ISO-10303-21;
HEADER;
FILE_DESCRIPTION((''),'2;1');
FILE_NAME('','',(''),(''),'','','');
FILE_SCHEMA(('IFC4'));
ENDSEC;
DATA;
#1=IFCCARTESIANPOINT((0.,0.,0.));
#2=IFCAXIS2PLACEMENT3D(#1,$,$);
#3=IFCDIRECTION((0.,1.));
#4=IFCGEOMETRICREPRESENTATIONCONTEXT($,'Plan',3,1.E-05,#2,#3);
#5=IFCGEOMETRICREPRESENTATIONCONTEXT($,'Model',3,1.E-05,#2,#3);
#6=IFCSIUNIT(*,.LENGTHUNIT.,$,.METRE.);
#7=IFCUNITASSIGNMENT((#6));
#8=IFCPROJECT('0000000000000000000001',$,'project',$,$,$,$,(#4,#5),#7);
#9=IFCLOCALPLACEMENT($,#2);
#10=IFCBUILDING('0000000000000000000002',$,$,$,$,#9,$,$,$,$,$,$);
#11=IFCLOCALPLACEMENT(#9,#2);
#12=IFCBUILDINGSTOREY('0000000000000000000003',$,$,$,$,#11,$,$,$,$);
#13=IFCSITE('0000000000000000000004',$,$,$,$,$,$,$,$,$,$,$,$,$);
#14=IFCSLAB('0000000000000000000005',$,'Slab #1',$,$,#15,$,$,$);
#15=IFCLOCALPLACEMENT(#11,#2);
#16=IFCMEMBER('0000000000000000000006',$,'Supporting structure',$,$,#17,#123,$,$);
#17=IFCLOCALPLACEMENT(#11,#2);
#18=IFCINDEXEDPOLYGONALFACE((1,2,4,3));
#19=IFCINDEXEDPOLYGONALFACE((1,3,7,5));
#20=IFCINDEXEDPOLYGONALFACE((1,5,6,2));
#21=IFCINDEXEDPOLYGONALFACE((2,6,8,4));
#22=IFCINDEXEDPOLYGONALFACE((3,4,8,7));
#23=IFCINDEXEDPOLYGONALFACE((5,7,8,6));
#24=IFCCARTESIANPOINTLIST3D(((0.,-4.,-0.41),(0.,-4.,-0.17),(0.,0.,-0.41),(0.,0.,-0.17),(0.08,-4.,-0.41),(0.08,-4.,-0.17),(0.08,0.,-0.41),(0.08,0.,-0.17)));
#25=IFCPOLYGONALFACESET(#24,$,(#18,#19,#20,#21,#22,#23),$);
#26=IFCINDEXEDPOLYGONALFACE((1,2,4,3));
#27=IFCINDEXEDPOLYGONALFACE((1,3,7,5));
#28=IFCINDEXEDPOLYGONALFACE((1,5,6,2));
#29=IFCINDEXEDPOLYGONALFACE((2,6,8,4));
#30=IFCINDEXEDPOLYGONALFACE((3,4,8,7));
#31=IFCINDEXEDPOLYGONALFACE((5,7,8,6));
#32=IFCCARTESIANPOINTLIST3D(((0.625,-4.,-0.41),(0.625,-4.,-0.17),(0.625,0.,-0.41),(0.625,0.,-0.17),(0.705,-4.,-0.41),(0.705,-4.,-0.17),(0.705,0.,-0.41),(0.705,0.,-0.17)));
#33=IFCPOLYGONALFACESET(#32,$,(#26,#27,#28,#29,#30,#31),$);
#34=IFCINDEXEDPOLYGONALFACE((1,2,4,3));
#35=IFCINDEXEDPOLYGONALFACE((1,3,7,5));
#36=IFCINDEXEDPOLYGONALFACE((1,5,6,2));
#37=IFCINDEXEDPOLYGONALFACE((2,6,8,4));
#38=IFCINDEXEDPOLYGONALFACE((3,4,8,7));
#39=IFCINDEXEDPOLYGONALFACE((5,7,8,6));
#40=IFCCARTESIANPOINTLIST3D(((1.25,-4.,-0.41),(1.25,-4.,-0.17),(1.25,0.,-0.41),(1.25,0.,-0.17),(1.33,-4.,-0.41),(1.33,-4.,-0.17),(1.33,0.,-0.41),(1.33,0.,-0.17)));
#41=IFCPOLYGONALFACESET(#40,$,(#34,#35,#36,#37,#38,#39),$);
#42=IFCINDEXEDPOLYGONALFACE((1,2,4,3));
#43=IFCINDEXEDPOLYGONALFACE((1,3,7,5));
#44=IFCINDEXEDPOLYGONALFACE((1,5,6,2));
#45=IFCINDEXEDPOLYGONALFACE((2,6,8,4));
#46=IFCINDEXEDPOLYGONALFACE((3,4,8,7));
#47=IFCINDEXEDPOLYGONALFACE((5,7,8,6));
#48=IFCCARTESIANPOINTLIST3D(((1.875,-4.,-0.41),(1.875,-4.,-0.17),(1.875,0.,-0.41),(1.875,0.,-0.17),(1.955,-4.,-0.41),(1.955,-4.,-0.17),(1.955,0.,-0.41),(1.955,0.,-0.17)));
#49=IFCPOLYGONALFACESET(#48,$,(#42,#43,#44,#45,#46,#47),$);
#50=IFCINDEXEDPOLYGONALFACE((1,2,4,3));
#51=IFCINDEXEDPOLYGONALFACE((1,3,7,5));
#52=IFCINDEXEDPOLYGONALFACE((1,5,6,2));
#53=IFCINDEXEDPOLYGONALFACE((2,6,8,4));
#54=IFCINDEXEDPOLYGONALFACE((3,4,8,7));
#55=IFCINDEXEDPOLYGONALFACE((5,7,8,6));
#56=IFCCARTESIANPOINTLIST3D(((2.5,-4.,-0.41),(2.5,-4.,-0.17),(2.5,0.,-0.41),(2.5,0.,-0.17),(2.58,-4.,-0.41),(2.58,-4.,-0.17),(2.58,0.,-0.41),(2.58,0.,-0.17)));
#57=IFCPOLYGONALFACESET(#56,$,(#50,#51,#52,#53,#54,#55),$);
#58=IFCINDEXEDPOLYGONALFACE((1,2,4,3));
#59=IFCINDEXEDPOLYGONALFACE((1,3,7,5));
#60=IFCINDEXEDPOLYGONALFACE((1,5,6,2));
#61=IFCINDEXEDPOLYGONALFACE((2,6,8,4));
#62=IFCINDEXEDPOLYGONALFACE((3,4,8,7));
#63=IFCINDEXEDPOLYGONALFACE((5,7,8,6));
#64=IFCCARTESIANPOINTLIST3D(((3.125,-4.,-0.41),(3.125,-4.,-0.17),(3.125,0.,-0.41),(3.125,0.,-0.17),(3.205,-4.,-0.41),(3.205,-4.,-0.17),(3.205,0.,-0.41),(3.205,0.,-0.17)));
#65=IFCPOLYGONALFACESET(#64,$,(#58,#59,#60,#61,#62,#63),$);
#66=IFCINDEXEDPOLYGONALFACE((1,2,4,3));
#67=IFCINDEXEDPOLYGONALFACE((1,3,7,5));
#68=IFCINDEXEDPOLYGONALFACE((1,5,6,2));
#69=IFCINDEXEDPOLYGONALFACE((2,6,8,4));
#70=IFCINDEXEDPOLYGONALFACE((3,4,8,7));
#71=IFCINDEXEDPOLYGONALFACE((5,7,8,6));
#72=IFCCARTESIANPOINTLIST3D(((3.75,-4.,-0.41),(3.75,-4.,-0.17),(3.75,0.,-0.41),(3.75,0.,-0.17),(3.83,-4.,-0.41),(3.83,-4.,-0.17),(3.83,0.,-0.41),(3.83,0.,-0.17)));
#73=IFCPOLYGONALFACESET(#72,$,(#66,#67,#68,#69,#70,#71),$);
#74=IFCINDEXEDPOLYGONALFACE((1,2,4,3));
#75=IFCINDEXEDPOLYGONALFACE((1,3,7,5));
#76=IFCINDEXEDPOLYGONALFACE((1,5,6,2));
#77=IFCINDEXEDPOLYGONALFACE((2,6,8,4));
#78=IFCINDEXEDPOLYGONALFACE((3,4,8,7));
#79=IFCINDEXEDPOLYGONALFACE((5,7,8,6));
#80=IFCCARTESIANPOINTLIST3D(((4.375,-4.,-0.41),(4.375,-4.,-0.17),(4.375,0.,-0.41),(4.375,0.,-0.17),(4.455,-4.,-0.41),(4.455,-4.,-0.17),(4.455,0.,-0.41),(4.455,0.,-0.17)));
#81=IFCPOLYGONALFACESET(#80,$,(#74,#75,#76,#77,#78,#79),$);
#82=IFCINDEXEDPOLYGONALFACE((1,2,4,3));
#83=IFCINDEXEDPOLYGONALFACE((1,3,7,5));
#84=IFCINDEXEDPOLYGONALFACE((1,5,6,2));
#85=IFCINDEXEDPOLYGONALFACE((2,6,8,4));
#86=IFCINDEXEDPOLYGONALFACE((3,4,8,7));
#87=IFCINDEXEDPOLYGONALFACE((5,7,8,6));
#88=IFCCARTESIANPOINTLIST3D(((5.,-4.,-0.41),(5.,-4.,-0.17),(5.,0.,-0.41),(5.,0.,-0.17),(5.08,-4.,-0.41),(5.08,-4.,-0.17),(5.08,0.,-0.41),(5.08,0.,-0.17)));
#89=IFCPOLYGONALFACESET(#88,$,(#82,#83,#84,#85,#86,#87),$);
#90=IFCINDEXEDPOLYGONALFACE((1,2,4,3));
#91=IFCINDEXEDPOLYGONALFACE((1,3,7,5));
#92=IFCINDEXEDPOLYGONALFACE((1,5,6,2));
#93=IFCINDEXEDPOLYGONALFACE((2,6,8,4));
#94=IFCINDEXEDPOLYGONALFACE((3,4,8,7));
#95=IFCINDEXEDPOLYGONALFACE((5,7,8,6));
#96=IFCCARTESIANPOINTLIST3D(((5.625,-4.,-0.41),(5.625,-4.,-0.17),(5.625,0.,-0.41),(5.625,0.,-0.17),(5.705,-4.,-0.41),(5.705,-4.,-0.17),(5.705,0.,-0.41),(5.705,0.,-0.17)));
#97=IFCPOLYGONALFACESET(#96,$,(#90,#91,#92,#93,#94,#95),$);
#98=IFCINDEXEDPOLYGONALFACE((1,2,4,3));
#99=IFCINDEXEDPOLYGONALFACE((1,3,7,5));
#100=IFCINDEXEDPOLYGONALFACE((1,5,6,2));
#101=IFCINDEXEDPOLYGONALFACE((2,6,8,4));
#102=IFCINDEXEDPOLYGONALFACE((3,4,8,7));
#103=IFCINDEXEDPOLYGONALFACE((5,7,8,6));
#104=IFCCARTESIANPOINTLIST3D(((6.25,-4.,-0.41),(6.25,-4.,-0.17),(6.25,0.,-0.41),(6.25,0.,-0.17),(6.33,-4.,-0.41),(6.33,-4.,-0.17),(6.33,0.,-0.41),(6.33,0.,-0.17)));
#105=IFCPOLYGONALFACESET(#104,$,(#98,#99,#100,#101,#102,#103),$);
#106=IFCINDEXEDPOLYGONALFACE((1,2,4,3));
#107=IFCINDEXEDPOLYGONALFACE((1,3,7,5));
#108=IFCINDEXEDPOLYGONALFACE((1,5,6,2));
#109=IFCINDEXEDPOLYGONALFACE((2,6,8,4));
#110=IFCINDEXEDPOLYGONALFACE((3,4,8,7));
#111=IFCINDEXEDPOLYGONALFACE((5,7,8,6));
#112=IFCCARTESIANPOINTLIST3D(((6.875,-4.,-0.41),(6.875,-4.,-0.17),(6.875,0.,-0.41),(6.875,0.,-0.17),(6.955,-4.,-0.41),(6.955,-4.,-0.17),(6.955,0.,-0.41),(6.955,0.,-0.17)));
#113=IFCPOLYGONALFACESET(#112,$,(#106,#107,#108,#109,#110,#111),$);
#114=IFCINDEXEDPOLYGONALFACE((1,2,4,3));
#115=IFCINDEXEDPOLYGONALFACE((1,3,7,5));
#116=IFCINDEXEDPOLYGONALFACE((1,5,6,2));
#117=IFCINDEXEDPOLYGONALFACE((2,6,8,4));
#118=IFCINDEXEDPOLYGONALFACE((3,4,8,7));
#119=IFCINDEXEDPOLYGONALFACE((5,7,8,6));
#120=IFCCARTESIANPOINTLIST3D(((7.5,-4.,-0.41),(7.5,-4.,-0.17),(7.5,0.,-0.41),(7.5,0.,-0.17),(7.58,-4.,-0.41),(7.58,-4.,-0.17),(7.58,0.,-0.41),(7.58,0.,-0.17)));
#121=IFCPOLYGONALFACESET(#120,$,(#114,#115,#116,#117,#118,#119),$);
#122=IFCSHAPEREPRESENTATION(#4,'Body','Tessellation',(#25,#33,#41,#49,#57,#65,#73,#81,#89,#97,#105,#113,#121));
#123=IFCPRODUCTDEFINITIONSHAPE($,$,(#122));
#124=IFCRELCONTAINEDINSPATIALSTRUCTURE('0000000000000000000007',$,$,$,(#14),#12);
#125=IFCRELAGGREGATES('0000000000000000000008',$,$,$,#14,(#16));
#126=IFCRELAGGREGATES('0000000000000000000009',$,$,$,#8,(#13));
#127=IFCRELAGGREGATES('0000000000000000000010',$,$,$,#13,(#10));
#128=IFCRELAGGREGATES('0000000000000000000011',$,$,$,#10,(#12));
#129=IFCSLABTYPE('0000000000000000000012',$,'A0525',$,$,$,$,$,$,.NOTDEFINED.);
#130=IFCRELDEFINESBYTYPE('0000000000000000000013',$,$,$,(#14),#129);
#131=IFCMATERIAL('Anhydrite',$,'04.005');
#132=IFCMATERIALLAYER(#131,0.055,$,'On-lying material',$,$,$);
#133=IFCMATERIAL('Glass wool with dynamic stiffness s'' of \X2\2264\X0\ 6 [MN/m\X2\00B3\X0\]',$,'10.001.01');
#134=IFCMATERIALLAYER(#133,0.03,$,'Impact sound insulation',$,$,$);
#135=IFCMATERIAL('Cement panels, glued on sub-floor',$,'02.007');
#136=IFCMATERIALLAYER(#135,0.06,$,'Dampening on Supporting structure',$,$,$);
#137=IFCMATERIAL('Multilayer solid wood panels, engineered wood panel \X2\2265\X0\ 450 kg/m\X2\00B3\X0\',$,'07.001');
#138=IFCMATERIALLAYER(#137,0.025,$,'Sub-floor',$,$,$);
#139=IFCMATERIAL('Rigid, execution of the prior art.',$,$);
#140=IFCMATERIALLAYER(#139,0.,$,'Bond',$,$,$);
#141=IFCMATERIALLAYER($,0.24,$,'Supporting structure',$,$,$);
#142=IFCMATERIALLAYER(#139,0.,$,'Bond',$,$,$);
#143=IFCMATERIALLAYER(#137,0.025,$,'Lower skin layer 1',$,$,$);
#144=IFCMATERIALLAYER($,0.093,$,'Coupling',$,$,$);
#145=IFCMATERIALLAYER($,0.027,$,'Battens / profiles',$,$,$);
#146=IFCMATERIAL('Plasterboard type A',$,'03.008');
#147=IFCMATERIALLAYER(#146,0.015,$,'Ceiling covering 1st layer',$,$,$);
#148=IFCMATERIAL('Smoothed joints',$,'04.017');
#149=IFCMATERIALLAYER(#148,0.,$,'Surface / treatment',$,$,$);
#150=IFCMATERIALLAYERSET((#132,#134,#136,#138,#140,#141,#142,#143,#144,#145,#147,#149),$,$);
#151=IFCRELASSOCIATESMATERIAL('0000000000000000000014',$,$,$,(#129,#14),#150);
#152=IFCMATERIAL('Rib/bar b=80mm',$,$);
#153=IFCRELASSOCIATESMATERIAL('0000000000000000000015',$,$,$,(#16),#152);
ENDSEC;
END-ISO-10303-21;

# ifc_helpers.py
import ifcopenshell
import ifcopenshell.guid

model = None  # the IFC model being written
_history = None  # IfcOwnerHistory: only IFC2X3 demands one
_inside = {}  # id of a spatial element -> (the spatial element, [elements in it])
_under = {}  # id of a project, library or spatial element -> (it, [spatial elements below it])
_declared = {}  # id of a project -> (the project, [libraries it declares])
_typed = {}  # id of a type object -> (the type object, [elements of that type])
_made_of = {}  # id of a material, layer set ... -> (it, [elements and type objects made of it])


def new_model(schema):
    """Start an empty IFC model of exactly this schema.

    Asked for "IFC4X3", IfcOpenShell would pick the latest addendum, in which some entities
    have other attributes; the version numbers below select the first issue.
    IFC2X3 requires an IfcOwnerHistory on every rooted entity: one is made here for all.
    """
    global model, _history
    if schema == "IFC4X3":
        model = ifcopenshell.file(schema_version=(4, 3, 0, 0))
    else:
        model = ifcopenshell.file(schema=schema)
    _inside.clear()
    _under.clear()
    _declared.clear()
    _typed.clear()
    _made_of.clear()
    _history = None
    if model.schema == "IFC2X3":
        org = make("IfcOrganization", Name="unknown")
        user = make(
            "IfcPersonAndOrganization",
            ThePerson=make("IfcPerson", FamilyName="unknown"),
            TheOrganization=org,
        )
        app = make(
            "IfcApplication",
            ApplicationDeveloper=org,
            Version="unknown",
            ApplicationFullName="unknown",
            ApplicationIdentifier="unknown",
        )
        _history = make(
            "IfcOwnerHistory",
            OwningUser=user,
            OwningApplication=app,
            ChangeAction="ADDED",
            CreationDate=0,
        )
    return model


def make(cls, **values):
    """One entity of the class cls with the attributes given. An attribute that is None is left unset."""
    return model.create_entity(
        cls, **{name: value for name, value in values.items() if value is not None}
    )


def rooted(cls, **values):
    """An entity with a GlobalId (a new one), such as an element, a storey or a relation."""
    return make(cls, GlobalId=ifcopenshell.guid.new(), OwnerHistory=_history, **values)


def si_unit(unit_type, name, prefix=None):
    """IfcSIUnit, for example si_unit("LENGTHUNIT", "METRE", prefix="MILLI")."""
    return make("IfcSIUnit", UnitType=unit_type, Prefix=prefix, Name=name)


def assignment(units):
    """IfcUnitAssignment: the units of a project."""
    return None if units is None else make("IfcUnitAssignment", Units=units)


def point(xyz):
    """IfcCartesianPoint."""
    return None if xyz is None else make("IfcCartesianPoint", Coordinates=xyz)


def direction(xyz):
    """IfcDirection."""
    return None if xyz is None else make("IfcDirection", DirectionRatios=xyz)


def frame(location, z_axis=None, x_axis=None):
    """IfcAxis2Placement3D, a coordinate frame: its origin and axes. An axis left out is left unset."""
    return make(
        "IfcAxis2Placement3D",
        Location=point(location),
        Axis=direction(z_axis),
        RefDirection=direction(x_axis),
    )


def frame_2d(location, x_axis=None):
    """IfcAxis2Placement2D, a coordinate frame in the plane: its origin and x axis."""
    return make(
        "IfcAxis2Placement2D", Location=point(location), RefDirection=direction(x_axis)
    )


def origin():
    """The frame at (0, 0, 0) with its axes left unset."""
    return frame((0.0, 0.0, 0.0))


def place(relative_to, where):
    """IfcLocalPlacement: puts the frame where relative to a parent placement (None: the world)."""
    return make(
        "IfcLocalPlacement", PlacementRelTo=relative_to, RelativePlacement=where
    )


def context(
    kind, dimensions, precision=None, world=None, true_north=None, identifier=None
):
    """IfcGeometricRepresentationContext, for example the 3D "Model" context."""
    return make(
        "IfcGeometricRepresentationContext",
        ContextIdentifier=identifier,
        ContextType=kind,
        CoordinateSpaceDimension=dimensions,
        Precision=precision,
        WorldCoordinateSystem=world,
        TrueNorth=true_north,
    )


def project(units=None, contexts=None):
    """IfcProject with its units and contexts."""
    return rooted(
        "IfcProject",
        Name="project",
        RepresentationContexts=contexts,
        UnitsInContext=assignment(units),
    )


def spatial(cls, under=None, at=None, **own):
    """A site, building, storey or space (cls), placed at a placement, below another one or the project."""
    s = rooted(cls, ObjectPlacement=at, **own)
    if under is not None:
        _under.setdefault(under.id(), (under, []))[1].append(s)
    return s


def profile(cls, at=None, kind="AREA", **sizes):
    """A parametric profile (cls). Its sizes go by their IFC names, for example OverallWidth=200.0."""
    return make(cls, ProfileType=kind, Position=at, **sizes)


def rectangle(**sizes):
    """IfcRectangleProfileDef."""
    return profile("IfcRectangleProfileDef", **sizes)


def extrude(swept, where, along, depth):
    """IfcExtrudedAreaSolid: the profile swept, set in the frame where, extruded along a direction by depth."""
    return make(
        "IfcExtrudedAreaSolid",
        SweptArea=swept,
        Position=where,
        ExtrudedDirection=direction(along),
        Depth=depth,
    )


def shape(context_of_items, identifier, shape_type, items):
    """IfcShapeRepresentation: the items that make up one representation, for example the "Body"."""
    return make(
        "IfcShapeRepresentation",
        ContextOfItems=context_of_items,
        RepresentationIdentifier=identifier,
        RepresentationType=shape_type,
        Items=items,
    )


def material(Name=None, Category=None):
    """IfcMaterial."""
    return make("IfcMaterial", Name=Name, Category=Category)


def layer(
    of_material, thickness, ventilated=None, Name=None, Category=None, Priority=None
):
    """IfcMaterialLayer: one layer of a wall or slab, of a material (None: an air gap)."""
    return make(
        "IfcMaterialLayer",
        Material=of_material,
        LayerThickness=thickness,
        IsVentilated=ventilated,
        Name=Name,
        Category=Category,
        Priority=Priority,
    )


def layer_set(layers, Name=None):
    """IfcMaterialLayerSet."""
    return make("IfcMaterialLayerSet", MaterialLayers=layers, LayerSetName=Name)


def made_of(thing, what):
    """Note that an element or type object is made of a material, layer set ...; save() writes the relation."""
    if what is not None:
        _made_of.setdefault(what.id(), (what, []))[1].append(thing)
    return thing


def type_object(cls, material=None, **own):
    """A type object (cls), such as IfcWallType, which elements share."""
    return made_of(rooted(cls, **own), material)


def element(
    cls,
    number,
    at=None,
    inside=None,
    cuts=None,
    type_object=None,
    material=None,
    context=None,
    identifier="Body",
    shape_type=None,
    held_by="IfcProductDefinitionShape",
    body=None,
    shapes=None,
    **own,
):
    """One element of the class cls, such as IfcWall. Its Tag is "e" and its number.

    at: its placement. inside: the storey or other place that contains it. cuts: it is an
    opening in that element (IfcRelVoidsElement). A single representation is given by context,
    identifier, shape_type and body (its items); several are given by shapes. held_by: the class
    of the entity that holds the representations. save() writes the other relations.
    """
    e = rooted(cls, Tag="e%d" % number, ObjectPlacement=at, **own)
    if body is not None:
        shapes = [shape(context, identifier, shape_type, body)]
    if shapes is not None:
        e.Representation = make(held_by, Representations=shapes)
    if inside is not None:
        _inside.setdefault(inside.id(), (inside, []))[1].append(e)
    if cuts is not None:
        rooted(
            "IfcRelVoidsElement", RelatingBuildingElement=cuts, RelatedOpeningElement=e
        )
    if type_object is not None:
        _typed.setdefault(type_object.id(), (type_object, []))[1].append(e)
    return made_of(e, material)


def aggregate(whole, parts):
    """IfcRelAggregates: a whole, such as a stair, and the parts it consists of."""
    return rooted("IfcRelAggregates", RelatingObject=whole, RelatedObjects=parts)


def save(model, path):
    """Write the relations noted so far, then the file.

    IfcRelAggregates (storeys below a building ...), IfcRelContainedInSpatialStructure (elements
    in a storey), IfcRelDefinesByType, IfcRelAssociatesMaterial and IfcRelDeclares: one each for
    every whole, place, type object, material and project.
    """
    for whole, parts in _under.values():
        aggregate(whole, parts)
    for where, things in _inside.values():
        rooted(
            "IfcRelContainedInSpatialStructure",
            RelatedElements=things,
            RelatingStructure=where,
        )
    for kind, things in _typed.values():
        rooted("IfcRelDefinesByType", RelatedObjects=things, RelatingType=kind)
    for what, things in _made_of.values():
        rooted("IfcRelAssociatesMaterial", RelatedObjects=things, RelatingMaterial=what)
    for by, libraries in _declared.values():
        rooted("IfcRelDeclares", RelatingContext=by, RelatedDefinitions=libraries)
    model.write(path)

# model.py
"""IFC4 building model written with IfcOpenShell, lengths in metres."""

from ifc_helpers import new_model, si_unit, direction, frame, frame_2d, origin, place, context, project, spatial, rectangle, extrude, material, layer, layer_set, type_object, element, aggregate, save


model = new_model("IFC4")

# Units and contexts
plan_context = context("Plan", 3, precision=1e-05, world=origin(), true_north=direction((0.0, 1.0)))
model_context = context("Model", 3, precision=1e-05, world=origin(), true_north=direction((0.0, 1.0)))
ifc_project = project(units=[si_unit("LENGTHUNIT", "METRE")], contexts=[plan_context, model_context])

# Site, building, storey
site = spatial("IfcSite", under=ifc_project)
building_placement = place(None, origin())
building = spatial("IfcBuilding", under=site, at=building_placement)
storey_placement = place(building_placement, origin())
storey = spatial("IfcBuildingStorey", under=building, at=storey_placement)

# Slab, member
ifc_material_1 = material(Name="Anhydrite", Category="04.005")
ifc_layer_1 = layer(ifc_material_1, 0.055, Name="On-lying material")
ifc_material_2 = material(Name="Glass wool with dynamic stiffness s' of ≤ 6 [MN/m³]", Category="10.001.01")
ifc_layer_2 = layer(ifc_material_2, 0.03, Name="Impact sound insulation")
ifc_material_3 = material(Name="Cement panels, glued on sub-floor", Category="02.007")
ifc_layer_3 = layer(ifc_material_3, 0.06, Name="Dampening on Supporting structure")
ifc_material_4 = material(Name="Multilayer solid wood panels, engineered wood panel ≥ 450 kg/m³", Category="07.001")
ifc_layer_4 = layer(ifc_material_4, 0.025, Name="Sub-floor")
ifc_material_5 = material(Name="Rigid, execution of the prior art.")
ifc_layer_5 = layer(ifc_material_5, 0.0, Name="Bond")
ifc_layer_6 = layer(None, 0.24, Name="Supporting structure")
ifc_layer_7 = layer(ifc_material_5, 0.0, Name="Bond")
ifc_layer_8 = layer(ifc_material_4, 0.025, Name="Lower skin layer 1")
ifc_layer_9 = layer(None, 0.093, Name="Coupling")
ifc_layer_10 = layer(None, 0.027, Name="Battens / profiles")
ifc_material_6 = material(Name="Plasterboard type A", Category="03.008")
ifc_layer_11 = layer(ifc_material_6, 0.015, Name="Ceiling covering 1st layer")
ifc_material_7 = material(Name="Smoothed joints", Category="04.017")
ifc_layer_12 = layer(ifc_material_7, 0.0, Name="Surface / treatment")
ifc_layer_set = layer_set([ifc_layer_1, ifc_layer_2, ifc_layer_3, ifc_layer_4, ifc_layer_5, ifc_layer_6, ifc_layer_7, ifc_layer_8, ifc_layer_9, ifc_layer_10, ifc_layer_11, ifc_layer_12])
slab_type = type_object("IfcSlabType", Name="A0525", PredefinedType="NOTDEFINED", material=ifc_layer_set)
slab_placement = place(None, frame((0.0, 0.0, 0.0), z_axis=(0.0, 0.0, -1.0), x_axis=(1.0, 0.0, 0.0)))
slab = element("IfcSlab", 1, at=slab_placement, inside=storey, type_object=slab_type, material=ifc_layer_set, Name="Slab #1")
ifc_material_8 = material(Name="Rib/bar b=80mm")
member_1_placement = place(slab_placement, origin())
member_1 = element("IfcMember", 2, at=member_1_placement, material=ifc_material_8, Name="Supporting structure", context=plan_context, shape_type="SweptSolid", body=[
    extrude(rectangle(XDim=0.08, YDim=0.24, at=frame_2d((0.04, 0.12), x_axis=(1.0, 0.0))), frame((0.0, 4.0, 0.17), z_axis=(0.0, -1.0, 0.0), x_axis=(1.0, 0.0, 0.0)), (0.0, 0.0, 1.0), 4.0),
    extrude(rectangle(XDim=0.08, YDim=0.24, at=frame_2d((0.04, 0.12), x_axis=(1.0, 0.0))), frame((0.625, 4.0, 0.17), z_axis=(0.0, -1.0, 0.0), x_axis=(1.0, 0.0, 0.0)), (0.0, 0.0, 1.0), 4.0),
    extrude(rectangle(XDim=0.08, YDim=0.24, at=frame_2d((0.04, 0.12), x_axis=(1.0, 0.0))), frame((1.25, 4.0, 0.17), z_axis=(0.0, -1.0, 0.0), x_axis=(1.0, 0.0, 0.0)), (0.0, 0.0, 1.0), 4.0),
    extrude(rectangle(XDim=0.08, YDim=0.24, at=frame_2d((0.04, 0.12), x_axis=(1.0, 0.0))), frame((1.875, 4.0, 0.17), z_axis=(0.0, -1.0, 0.0), x_axis=(1.0, 0.0, 0.0)), (0.0, 0.0, 1.0), 4.0),
    extrude(rectangle(XDim=0.08, YDim=0.24, at=frame_2d((0.04, 0.12), x_axis=(1.0, 0.0))), frame((2.5, 4.0, 0.17), z_axis=(0.0, -1.0, 0.0), x_axis=(1.0, 0.0, 0.0)), (0.0, 0.0, 1.0), 4.0),
    extrude(rectangle(XDim=0.08, YDim=0.24, at=frame_2d((0.04, 0.12), x_axis=(1.0, 0.0))), frame((3.125, 4.0, 0.17), z_axis=(0.0, -1.0, 0.0), x_axis=(1.0, 0.0, 0.0)), (0.0, 0.0, 1.0), 4.0),
    extrude(rectangle(XDim=0.08, YDim=0.24, at=frame_2d((0.04, 0.12), x_axis=(1.0, 0.0))), frame((3.75, 4.0, 0.17), z_axis=(0.0, -1.0, 0.0), x_axis=(1.0, 0.0, 0.0)), (0.0, 0.0, 1.0), 4.0),
    extrude(rectangle(XDim=0.08, YDim=0.24, at=frame_2d((0.04, 0.12), x_axis=(1.0, 0.0))), frame((4.375, 4.0, 0.17), z_axis=(0.0, -1.0, 0.0), x_axis=(1.0, 0.0, 0.0)), (0.0, 0.0, 1.0), 4.0),
    extrude(rectangle(XDim=0.08, YDim=0.24, at=frame_2d((0.04, 0.12), x_axis=(1.0, 0.0))), frame((5.0, 4.0, 0.17), z_axis=(0.0, -1.0, 0.0), x_axis=(1.0, 0.0, 0.0)), (0.0, 0.0, 1.0), 4.0),
    extrude(rectangle(XDim=0.08, YDim=0.24, at=frame_2d((0.04, 0.12), x_axis=(1.0, 0.0))), frame((5.625, 4.0, 0.17), z_axis=(0.0, -1.0, 0.0), x_axis=(1.0, 0.0, 0.0)), (0.0, 0.0, 1.0), 4.0),
    extrude(rectangle(XDim=0.08, YDim=0.24, at=frame_2d((0.04, 0.12), x_axis=(1.0, 0.0))), frame((6.25, 4.0, 0.17), z_axis=(0.0, -1.0, 0.0), x_axis=(1.0, 0.0, 0.0)), (0.0, 0.0, 1.0), 4.0),
    extrude(rectangle(XDim=0.08, YDim=0.24, at=frame_2d((0.04, 0.12), x_axis=(1.0, 0.0))), frame((6.875, 4.0, 0.17), z_axis=(0.0, -1.0, 0.0), x_axis=(1.0, 0.0, 0.0)), (0.0, 0.0, 1.0), 4.0),
    extrude(rectangle(XDim=0.08, YDim=0.24, at=frame_2d((0.04, 0.12), x_axis=(1.0, 0.0))), frame((7.5, 4.0, 0.17), z_axis=(0.0, -1.0, 0.0), x_axis=(1.0, 0.0, 0.0)), (0.0, 0.0, 1.0), 4.0),
])
aggregate(slab, [member_1])

save(model, "model.ifc")
